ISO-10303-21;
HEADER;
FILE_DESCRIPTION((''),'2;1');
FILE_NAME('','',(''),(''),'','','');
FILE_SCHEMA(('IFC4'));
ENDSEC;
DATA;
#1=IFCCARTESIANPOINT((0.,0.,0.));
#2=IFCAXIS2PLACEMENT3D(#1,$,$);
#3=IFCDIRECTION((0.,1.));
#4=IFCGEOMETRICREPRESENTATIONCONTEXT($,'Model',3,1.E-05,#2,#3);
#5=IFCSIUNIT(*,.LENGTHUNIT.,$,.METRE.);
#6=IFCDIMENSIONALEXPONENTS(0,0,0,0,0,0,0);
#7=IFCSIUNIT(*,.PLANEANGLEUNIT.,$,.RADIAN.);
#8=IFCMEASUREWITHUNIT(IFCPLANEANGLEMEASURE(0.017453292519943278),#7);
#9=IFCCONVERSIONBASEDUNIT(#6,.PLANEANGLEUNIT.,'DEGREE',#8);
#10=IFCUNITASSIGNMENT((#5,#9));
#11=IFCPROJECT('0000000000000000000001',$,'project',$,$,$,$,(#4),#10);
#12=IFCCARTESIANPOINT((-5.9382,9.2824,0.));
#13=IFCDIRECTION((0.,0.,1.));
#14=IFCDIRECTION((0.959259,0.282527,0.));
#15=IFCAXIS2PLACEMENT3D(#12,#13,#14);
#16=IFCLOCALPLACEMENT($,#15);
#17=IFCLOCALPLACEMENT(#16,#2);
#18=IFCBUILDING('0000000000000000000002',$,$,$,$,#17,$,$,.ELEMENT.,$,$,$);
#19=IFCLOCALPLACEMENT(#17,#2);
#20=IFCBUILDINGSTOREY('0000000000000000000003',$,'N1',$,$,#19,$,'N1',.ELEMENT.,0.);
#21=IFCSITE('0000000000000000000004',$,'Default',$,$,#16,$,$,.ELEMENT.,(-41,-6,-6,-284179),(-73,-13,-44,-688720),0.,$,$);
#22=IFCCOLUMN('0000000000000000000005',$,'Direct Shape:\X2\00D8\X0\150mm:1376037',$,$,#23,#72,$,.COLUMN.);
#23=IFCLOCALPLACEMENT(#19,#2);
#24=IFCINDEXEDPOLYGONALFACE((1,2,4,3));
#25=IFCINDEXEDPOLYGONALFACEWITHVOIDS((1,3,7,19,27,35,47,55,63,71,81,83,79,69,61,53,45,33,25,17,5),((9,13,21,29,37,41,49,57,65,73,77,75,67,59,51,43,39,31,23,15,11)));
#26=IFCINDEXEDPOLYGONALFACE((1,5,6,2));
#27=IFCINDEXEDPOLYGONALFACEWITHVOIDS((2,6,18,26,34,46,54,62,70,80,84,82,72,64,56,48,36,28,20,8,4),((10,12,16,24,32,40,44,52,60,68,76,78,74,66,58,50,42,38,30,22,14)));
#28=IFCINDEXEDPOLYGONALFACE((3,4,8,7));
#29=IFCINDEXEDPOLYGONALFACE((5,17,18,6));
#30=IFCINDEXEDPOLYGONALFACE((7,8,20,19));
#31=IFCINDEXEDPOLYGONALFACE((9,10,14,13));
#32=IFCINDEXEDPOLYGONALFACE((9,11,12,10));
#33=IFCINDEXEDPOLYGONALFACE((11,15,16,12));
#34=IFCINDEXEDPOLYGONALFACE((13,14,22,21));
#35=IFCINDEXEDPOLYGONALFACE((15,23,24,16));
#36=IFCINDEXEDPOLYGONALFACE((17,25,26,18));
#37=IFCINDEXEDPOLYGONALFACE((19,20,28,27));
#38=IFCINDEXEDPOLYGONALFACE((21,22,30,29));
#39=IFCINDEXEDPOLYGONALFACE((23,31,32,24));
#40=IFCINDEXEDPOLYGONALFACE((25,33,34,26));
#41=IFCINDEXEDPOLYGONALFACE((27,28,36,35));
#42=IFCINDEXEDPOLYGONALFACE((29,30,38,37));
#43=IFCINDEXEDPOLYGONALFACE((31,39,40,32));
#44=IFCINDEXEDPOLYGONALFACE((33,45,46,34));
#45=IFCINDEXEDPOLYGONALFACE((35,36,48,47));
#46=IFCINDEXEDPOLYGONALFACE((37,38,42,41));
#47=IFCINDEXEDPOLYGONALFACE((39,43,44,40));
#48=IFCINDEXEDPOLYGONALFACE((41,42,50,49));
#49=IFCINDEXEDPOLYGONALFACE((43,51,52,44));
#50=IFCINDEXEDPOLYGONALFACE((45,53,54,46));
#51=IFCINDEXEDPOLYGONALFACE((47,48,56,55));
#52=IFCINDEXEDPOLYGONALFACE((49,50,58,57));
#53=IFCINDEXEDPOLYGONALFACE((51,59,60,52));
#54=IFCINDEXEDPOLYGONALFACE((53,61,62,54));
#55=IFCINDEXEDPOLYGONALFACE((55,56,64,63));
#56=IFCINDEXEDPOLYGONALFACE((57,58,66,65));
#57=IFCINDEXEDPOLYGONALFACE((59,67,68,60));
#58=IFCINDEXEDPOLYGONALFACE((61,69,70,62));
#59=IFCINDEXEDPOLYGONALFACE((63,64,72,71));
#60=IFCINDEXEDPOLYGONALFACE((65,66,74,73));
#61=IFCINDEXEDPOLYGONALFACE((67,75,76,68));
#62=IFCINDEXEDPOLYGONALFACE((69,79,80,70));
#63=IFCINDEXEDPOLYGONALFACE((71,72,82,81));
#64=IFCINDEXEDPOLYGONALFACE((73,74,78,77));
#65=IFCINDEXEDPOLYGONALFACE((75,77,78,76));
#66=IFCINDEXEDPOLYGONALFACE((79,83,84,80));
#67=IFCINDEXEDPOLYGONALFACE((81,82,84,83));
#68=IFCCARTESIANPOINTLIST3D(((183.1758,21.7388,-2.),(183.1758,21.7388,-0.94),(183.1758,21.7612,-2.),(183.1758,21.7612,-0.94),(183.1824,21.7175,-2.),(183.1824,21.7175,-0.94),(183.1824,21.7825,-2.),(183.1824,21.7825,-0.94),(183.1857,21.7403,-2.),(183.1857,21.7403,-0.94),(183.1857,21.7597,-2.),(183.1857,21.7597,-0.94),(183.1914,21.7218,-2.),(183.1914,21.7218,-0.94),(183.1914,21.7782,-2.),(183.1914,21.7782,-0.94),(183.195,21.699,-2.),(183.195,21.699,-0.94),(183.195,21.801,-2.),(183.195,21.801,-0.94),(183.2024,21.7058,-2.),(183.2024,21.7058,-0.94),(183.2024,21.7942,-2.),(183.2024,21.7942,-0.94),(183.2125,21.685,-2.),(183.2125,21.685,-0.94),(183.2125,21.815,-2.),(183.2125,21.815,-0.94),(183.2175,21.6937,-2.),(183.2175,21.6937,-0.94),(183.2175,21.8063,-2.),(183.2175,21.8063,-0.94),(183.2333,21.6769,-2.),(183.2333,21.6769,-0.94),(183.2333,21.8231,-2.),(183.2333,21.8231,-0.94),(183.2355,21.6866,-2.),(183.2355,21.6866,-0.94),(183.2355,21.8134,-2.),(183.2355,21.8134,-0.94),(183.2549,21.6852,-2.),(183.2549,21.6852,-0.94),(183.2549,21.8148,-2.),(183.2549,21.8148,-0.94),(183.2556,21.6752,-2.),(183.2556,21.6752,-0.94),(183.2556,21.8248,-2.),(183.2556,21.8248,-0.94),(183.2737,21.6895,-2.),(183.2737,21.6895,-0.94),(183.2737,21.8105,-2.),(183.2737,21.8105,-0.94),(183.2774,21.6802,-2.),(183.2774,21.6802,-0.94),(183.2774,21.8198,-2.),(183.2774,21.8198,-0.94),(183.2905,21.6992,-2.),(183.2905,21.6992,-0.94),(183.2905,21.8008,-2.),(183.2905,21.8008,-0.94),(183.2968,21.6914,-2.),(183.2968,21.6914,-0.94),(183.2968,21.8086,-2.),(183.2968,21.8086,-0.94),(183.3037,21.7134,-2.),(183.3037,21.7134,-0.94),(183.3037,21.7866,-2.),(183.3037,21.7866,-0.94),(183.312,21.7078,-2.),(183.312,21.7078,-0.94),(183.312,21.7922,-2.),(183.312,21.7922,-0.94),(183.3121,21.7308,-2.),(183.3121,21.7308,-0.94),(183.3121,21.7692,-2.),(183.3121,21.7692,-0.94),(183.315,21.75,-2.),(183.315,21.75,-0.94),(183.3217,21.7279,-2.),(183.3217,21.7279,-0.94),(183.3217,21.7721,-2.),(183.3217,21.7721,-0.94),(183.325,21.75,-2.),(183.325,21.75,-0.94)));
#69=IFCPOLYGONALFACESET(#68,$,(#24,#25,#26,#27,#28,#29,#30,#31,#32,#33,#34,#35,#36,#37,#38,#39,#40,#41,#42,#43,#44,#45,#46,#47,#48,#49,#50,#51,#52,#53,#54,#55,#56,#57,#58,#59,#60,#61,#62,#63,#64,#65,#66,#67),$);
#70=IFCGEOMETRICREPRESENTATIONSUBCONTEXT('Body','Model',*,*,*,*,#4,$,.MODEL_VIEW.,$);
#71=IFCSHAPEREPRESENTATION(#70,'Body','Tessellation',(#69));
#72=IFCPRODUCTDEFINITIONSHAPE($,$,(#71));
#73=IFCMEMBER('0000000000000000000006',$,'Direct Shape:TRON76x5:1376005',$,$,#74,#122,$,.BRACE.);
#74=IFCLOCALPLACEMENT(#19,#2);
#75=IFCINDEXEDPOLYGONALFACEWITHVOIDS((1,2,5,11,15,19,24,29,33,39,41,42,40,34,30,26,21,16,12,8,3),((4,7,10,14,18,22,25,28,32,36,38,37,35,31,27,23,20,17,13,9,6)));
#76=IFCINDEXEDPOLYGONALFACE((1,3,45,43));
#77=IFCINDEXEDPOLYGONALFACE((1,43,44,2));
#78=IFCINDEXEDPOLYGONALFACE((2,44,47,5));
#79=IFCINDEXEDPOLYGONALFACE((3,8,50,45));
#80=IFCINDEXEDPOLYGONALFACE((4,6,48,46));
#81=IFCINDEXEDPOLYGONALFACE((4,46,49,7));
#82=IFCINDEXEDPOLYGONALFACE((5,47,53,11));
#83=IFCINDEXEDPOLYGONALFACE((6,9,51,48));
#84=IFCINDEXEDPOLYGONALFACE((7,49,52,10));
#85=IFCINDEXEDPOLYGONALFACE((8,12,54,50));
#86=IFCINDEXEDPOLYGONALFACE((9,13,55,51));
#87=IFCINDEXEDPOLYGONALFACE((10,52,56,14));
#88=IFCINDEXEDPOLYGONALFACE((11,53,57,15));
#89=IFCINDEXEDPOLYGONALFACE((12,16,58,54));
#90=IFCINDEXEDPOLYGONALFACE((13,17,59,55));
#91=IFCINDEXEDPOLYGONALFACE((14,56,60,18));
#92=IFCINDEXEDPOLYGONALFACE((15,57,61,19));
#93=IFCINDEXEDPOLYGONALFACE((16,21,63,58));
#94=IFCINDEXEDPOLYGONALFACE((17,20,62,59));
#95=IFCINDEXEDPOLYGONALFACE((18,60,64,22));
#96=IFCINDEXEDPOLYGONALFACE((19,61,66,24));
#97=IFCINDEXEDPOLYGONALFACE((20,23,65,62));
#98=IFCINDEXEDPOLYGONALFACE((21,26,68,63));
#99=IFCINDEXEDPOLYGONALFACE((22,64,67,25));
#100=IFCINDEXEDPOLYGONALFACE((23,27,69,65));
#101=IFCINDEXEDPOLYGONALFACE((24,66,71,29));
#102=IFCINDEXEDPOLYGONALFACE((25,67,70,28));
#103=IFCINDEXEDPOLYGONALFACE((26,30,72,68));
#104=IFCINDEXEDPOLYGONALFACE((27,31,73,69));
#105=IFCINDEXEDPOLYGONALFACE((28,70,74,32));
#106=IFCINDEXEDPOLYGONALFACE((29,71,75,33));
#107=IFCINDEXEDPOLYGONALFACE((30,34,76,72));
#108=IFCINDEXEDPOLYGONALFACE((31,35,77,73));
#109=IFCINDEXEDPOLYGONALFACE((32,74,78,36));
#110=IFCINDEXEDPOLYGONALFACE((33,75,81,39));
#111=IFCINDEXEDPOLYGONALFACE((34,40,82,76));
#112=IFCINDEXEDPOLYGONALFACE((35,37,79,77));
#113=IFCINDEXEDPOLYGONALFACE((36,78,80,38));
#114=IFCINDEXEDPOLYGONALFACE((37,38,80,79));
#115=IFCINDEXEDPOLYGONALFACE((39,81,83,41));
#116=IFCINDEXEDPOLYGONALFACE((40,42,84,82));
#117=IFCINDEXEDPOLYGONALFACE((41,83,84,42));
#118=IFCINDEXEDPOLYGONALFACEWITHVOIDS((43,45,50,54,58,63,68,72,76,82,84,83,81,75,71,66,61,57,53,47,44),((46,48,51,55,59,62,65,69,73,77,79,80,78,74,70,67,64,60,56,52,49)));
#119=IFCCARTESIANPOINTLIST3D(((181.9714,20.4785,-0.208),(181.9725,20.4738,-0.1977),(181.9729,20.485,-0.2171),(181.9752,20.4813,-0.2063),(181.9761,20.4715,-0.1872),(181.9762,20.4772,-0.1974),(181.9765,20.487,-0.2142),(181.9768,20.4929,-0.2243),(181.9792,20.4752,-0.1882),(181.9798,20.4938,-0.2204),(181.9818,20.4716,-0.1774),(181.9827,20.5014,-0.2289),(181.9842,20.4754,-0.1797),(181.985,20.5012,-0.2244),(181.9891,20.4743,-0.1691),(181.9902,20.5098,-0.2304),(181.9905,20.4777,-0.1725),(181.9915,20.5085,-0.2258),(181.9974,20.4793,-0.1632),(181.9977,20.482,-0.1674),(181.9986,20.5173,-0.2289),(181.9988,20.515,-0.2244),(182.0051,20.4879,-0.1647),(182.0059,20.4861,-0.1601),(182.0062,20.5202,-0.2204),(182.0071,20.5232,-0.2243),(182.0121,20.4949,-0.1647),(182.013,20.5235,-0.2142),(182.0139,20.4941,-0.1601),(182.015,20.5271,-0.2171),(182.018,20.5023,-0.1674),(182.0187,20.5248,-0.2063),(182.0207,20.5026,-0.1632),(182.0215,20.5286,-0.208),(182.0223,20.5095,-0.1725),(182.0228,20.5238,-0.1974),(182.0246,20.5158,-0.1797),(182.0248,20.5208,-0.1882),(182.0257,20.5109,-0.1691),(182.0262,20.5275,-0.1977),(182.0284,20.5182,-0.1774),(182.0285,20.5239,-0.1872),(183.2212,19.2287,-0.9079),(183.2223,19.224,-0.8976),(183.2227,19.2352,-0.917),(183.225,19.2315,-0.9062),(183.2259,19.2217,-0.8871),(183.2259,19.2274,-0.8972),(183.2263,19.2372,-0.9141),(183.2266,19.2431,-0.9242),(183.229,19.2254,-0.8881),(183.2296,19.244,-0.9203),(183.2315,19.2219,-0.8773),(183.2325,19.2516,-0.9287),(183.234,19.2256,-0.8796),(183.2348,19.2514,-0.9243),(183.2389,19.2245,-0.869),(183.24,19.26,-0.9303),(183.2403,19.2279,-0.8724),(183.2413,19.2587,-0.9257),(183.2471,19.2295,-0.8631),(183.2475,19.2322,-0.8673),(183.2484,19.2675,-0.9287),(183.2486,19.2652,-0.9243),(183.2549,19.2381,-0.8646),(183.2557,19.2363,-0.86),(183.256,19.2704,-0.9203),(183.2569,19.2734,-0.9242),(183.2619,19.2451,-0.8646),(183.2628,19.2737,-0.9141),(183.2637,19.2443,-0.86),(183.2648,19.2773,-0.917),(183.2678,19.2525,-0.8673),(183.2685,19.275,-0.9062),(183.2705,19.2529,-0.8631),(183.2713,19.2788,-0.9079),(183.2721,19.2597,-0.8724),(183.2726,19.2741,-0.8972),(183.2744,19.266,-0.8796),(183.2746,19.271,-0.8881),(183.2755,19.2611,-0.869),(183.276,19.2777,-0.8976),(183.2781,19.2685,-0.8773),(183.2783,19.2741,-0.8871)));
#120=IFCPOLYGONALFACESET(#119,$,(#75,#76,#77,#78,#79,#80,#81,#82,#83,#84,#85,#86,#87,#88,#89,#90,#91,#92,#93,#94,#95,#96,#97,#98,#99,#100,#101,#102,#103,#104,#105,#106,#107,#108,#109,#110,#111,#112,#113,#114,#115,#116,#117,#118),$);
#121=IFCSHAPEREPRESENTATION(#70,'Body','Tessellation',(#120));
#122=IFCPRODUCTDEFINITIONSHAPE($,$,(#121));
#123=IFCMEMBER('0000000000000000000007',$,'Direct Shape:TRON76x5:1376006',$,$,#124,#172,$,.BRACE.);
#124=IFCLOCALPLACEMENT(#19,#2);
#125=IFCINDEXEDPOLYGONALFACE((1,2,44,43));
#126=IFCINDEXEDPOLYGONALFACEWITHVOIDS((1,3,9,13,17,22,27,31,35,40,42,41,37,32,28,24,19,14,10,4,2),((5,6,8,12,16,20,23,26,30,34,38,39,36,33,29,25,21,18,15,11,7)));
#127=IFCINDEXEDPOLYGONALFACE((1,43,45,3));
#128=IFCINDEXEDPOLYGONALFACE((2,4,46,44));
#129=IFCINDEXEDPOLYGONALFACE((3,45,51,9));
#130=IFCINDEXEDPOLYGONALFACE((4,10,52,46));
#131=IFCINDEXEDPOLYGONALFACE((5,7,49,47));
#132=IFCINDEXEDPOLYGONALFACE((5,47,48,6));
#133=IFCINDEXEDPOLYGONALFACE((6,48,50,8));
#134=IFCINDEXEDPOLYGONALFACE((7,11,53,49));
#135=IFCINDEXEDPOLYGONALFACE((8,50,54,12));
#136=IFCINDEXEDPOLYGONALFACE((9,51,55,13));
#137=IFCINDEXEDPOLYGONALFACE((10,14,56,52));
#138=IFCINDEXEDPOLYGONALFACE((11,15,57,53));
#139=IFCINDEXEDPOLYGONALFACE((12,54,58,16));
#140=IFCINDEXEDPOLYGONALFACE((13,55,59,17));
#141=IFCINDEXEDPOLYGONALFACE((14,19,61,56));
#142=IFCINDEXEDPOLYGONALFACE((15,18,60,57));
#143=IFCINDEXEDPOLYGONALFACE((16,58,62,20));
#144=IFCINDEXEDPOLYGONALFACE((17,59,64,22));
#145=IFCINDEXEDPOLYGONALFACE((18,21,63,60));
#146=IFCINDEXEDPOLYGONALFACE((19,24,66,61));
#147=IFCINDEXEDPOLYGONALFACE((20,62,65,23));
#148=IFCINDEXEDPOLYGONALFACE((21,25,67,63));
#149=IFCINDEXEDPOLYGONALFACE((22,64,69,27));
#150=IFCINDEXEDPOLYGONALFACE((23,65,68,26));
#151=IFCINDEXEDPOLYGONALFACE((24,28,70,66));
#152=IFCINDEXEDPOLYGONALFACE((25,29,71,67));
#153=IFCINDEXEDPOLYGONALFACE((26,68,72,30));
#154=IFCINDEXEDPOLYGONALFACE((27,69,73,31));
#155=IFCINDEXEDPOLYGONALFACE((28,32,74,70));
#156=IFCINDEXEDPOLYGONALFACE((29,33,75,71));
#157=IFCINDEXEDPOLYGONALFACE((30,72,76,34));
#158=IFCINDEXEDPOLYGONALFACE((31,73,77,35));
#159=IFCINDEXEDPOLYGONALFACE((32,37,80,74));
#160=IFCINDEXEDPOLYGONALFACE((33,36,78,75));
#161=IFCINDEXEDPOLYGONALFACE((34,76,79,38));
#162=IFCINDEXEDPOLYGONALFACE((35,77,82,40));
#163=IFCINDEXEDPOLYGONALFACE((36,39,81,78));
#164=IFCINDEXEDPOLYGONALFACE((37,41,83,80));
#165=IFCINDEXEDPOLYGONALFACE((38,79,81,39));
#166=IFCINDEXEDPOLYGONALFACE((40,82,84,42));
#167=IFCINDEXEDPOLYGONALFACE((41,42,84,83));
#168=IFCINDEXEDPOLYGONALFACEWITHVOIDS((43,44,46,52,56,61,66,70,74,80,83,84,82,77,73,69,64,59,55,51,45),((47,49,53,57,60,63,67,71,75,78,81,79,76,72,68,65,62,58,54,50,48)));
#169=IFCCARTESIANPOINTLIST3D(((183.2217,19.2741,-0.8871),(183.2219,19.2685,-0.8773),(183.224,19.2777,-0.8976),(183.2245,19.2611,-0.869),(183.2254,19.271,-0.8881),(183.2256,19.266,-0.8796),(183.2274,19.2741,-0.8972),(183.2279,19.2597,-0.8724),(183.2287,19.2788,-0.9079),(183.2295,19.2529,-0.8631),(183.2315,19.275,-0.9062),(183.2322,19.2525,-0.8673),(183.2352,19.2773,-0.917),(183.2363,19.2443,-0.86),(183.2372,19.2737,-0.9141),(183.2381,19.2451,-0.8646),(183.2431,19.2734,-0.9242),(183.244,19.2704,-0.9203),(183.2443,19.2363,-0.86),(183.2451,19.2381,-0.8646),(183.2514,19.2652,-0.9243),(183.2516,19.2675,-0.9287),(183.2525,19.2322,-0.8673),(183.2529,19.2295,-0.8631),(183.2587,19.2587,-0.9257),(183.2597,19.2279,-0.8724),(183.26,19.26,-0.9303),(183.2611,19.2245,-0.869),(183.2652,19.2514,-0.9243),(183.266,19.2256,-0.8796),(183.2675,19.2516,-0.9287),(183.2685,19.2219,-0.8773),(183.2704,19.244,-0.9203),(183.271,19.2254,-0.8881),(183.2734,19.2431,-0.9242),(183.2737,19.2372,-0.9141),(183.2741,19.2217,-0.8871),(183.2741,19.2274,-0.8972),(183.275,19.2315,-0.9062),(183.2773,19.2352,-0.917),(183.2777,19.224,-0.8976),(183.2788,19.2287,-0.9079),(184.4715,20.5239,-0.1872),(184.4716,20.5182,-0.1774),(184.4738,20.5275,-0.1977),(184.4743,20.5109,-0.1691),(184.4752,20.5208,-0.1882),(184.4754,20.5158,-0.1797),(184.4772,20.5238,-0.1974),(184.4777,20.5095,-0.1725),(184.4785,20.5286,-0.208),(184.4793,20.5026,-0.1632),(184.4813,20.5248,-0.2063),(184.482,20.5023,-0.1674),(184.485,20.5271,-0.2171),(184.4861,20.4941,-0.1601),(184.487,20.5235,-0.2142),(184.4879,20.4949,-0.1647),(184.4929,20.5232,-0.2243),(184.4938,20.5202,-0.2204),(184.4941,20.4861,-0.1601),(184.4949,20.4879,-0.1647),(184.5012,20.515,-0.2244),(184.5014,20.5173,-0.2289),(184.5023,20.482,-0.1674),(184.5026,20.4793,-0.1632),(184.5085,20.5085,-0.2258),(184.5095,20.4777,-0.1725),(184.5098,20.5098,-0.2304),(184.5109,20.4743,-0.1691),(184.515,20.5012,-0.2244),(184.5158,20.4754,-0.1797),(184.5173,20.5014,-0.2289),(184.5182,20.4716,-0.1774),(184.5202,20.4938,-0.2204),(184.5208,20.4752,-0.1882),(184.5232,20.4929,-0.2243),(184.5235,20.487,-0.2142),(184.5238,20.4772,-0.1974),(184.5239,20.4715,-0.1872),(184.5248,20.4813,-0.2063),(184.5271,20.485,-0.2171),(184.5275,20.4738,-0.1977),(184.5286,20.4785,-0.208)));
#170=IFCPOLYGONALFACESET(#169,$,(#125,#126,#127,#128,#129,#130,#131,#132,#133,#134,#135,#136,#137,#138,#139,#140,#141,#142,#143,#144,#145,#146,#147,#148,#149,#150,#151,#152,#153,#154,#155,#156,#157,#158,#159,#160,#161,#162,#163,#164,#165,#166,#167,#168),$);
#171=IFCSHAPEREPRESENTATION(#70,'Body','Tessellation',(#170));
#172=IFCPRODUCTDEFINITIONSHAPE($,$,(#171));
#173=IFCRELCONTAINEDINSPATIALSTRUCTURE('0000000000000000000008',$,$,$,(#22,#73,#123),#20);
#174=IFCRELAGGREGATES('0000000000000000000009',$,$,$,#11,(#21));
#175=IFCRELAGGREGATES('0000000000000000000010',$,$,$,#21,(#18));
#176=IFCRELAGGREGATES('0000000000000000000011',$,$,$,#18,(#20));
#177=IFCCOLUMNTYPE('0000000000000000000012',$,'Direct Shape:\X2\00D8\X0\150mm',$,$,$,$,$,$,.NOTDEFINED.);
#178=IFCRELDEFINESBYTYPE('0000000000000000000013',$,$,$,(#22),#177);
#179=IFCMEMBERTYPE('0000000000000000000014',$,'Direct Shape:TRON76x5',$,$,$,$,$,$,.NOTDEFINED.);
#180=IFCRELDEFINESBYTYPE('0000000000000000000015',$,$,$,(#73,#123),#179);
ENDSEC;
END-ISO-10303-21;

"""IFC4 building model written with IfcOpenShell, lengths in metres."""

from ifc_helpers import new_model, entity, si_unit, converted_unit, direction, frame, frame_2d, origin, origin_2d_with_axis, place, context, subcontext, project, spatial, hollow_circle, extrude, type_object, element, save


model = new_model("IFC4")

# Units and contexts
model_context = context("Model", 3, precision=1e-05, world=origin(), true_north=direction((0.0, 1.0)))
body_context = subcontext(model_context, "Body", "Model", "MODEL_VIEW")
ifc_project = project(units=[si_unit("LENGTHUNIT", "METRE"), converted_unit("PLANEANGLEUNIT", "DEGREE", entity("IfcPlaneAngleMeasure", 0.017453292519943278), si_unit("PLANEANGLEUNIT", "RADIAN"), dimensions=[0, 0, 0, 0, 0, 0, 0])], contexts=[model_context])

# Site, building, storey
site_placement = place(None, frame((-5.9382, 9.2824, 0.0), z_axis=(0.0, 0.0, 1.0), x_axis=(0.959259, 0.282527, 0.0)))
site = spatial("IfcSite", under=ifc_project, at=site_placement, Name="Default", CompositionType="ELEMENT", RefLatitude=(-41, -6, -6, -284179), RefLongitude=(-73, -13, -44, -688720), RefElevation=0.0)
building_placement = place(site_placement, origin())
building = spatial("IfcBuilding", under=site, at=building_placement, CompositionType="ELEMENT")
storey_placement = place(building_placement, origin())
storey = spatial("IfcBuildingStorey", under=building, at=storey_placement, Name="N1", LongName="N1", CompositionType="ELEMENT", Elevation=0.0)

# Column
column_type = type_object("IfcColumnType", Name="Direct Shape:Ø150mm", PredefinedType="NOTDEFINED")
column_placement = place(storey_placement, origin())
element("IfcColumn", 1, at=column_placement, inside=storey, type_object=column_type, Name="Direct Shape:Ø150mm:1376037", PredefinedType="COLUMN", context=body_context, shape_type="SweptSolid", body=[
    extrude(hollow_circle(Radius=0.075, WallThickness=0.01, at=origin_2d_with_axis()), frame((183.25, 21.75, -2.0)), (0.0, 0.0, 1.0), 1.06),
])

# Members
member_type_1 = type_object("IfcMemberType", Name="Direct Shape:TRON76x5", PredefinedType="NOTDEFINED")
member_1_placement = place(storey_placement, origin())
element("IfcMember", 2, at=member_1_placement, inside=storey, type_object=member_type_1, Name="Direct Shape:TRON76x5:1376005", PredefinedType="BRACE", context=body_context, shape_type="SweptSolid", body=[
    extrude(hollow_circle(Radius=0.0381, WallThickness=0.005, at=frame_2d((0.0, 0.0), x_axis=(1.0, 0.0))), frame((183.2499, 19.2501, -0.8949), z_axis=(-0.65744, 0.65744, 0.368166), x_axis=(-0.260333, 0.260333, -0.92976)), (0.0, 0.0, 1.0), 1.901),
])
member_2_placement = place(storey_placement, origin())
element("IfcMember", 3, at=member_2_placement, inside=storey, type_object=member_type_1, Name="Direct Shape:TRON76x5:1376006", PredefinedType="BRACE", context=body_context, shape_type="SweptSolid", body=[
    extrude(hollow_circle(Radius=0.0381, WallThickness=0.005, at=origin_2d_with_axis()), frame((183.2501, 19.2501, -0.8949), z_axis=(0.65744, 0.65744, 0.368166), x_axis=(0.260333, 0.260333, -0.92976)), (0.0, 0.0, 1.0), 1.901),
])

save(model, "model.ifc")
